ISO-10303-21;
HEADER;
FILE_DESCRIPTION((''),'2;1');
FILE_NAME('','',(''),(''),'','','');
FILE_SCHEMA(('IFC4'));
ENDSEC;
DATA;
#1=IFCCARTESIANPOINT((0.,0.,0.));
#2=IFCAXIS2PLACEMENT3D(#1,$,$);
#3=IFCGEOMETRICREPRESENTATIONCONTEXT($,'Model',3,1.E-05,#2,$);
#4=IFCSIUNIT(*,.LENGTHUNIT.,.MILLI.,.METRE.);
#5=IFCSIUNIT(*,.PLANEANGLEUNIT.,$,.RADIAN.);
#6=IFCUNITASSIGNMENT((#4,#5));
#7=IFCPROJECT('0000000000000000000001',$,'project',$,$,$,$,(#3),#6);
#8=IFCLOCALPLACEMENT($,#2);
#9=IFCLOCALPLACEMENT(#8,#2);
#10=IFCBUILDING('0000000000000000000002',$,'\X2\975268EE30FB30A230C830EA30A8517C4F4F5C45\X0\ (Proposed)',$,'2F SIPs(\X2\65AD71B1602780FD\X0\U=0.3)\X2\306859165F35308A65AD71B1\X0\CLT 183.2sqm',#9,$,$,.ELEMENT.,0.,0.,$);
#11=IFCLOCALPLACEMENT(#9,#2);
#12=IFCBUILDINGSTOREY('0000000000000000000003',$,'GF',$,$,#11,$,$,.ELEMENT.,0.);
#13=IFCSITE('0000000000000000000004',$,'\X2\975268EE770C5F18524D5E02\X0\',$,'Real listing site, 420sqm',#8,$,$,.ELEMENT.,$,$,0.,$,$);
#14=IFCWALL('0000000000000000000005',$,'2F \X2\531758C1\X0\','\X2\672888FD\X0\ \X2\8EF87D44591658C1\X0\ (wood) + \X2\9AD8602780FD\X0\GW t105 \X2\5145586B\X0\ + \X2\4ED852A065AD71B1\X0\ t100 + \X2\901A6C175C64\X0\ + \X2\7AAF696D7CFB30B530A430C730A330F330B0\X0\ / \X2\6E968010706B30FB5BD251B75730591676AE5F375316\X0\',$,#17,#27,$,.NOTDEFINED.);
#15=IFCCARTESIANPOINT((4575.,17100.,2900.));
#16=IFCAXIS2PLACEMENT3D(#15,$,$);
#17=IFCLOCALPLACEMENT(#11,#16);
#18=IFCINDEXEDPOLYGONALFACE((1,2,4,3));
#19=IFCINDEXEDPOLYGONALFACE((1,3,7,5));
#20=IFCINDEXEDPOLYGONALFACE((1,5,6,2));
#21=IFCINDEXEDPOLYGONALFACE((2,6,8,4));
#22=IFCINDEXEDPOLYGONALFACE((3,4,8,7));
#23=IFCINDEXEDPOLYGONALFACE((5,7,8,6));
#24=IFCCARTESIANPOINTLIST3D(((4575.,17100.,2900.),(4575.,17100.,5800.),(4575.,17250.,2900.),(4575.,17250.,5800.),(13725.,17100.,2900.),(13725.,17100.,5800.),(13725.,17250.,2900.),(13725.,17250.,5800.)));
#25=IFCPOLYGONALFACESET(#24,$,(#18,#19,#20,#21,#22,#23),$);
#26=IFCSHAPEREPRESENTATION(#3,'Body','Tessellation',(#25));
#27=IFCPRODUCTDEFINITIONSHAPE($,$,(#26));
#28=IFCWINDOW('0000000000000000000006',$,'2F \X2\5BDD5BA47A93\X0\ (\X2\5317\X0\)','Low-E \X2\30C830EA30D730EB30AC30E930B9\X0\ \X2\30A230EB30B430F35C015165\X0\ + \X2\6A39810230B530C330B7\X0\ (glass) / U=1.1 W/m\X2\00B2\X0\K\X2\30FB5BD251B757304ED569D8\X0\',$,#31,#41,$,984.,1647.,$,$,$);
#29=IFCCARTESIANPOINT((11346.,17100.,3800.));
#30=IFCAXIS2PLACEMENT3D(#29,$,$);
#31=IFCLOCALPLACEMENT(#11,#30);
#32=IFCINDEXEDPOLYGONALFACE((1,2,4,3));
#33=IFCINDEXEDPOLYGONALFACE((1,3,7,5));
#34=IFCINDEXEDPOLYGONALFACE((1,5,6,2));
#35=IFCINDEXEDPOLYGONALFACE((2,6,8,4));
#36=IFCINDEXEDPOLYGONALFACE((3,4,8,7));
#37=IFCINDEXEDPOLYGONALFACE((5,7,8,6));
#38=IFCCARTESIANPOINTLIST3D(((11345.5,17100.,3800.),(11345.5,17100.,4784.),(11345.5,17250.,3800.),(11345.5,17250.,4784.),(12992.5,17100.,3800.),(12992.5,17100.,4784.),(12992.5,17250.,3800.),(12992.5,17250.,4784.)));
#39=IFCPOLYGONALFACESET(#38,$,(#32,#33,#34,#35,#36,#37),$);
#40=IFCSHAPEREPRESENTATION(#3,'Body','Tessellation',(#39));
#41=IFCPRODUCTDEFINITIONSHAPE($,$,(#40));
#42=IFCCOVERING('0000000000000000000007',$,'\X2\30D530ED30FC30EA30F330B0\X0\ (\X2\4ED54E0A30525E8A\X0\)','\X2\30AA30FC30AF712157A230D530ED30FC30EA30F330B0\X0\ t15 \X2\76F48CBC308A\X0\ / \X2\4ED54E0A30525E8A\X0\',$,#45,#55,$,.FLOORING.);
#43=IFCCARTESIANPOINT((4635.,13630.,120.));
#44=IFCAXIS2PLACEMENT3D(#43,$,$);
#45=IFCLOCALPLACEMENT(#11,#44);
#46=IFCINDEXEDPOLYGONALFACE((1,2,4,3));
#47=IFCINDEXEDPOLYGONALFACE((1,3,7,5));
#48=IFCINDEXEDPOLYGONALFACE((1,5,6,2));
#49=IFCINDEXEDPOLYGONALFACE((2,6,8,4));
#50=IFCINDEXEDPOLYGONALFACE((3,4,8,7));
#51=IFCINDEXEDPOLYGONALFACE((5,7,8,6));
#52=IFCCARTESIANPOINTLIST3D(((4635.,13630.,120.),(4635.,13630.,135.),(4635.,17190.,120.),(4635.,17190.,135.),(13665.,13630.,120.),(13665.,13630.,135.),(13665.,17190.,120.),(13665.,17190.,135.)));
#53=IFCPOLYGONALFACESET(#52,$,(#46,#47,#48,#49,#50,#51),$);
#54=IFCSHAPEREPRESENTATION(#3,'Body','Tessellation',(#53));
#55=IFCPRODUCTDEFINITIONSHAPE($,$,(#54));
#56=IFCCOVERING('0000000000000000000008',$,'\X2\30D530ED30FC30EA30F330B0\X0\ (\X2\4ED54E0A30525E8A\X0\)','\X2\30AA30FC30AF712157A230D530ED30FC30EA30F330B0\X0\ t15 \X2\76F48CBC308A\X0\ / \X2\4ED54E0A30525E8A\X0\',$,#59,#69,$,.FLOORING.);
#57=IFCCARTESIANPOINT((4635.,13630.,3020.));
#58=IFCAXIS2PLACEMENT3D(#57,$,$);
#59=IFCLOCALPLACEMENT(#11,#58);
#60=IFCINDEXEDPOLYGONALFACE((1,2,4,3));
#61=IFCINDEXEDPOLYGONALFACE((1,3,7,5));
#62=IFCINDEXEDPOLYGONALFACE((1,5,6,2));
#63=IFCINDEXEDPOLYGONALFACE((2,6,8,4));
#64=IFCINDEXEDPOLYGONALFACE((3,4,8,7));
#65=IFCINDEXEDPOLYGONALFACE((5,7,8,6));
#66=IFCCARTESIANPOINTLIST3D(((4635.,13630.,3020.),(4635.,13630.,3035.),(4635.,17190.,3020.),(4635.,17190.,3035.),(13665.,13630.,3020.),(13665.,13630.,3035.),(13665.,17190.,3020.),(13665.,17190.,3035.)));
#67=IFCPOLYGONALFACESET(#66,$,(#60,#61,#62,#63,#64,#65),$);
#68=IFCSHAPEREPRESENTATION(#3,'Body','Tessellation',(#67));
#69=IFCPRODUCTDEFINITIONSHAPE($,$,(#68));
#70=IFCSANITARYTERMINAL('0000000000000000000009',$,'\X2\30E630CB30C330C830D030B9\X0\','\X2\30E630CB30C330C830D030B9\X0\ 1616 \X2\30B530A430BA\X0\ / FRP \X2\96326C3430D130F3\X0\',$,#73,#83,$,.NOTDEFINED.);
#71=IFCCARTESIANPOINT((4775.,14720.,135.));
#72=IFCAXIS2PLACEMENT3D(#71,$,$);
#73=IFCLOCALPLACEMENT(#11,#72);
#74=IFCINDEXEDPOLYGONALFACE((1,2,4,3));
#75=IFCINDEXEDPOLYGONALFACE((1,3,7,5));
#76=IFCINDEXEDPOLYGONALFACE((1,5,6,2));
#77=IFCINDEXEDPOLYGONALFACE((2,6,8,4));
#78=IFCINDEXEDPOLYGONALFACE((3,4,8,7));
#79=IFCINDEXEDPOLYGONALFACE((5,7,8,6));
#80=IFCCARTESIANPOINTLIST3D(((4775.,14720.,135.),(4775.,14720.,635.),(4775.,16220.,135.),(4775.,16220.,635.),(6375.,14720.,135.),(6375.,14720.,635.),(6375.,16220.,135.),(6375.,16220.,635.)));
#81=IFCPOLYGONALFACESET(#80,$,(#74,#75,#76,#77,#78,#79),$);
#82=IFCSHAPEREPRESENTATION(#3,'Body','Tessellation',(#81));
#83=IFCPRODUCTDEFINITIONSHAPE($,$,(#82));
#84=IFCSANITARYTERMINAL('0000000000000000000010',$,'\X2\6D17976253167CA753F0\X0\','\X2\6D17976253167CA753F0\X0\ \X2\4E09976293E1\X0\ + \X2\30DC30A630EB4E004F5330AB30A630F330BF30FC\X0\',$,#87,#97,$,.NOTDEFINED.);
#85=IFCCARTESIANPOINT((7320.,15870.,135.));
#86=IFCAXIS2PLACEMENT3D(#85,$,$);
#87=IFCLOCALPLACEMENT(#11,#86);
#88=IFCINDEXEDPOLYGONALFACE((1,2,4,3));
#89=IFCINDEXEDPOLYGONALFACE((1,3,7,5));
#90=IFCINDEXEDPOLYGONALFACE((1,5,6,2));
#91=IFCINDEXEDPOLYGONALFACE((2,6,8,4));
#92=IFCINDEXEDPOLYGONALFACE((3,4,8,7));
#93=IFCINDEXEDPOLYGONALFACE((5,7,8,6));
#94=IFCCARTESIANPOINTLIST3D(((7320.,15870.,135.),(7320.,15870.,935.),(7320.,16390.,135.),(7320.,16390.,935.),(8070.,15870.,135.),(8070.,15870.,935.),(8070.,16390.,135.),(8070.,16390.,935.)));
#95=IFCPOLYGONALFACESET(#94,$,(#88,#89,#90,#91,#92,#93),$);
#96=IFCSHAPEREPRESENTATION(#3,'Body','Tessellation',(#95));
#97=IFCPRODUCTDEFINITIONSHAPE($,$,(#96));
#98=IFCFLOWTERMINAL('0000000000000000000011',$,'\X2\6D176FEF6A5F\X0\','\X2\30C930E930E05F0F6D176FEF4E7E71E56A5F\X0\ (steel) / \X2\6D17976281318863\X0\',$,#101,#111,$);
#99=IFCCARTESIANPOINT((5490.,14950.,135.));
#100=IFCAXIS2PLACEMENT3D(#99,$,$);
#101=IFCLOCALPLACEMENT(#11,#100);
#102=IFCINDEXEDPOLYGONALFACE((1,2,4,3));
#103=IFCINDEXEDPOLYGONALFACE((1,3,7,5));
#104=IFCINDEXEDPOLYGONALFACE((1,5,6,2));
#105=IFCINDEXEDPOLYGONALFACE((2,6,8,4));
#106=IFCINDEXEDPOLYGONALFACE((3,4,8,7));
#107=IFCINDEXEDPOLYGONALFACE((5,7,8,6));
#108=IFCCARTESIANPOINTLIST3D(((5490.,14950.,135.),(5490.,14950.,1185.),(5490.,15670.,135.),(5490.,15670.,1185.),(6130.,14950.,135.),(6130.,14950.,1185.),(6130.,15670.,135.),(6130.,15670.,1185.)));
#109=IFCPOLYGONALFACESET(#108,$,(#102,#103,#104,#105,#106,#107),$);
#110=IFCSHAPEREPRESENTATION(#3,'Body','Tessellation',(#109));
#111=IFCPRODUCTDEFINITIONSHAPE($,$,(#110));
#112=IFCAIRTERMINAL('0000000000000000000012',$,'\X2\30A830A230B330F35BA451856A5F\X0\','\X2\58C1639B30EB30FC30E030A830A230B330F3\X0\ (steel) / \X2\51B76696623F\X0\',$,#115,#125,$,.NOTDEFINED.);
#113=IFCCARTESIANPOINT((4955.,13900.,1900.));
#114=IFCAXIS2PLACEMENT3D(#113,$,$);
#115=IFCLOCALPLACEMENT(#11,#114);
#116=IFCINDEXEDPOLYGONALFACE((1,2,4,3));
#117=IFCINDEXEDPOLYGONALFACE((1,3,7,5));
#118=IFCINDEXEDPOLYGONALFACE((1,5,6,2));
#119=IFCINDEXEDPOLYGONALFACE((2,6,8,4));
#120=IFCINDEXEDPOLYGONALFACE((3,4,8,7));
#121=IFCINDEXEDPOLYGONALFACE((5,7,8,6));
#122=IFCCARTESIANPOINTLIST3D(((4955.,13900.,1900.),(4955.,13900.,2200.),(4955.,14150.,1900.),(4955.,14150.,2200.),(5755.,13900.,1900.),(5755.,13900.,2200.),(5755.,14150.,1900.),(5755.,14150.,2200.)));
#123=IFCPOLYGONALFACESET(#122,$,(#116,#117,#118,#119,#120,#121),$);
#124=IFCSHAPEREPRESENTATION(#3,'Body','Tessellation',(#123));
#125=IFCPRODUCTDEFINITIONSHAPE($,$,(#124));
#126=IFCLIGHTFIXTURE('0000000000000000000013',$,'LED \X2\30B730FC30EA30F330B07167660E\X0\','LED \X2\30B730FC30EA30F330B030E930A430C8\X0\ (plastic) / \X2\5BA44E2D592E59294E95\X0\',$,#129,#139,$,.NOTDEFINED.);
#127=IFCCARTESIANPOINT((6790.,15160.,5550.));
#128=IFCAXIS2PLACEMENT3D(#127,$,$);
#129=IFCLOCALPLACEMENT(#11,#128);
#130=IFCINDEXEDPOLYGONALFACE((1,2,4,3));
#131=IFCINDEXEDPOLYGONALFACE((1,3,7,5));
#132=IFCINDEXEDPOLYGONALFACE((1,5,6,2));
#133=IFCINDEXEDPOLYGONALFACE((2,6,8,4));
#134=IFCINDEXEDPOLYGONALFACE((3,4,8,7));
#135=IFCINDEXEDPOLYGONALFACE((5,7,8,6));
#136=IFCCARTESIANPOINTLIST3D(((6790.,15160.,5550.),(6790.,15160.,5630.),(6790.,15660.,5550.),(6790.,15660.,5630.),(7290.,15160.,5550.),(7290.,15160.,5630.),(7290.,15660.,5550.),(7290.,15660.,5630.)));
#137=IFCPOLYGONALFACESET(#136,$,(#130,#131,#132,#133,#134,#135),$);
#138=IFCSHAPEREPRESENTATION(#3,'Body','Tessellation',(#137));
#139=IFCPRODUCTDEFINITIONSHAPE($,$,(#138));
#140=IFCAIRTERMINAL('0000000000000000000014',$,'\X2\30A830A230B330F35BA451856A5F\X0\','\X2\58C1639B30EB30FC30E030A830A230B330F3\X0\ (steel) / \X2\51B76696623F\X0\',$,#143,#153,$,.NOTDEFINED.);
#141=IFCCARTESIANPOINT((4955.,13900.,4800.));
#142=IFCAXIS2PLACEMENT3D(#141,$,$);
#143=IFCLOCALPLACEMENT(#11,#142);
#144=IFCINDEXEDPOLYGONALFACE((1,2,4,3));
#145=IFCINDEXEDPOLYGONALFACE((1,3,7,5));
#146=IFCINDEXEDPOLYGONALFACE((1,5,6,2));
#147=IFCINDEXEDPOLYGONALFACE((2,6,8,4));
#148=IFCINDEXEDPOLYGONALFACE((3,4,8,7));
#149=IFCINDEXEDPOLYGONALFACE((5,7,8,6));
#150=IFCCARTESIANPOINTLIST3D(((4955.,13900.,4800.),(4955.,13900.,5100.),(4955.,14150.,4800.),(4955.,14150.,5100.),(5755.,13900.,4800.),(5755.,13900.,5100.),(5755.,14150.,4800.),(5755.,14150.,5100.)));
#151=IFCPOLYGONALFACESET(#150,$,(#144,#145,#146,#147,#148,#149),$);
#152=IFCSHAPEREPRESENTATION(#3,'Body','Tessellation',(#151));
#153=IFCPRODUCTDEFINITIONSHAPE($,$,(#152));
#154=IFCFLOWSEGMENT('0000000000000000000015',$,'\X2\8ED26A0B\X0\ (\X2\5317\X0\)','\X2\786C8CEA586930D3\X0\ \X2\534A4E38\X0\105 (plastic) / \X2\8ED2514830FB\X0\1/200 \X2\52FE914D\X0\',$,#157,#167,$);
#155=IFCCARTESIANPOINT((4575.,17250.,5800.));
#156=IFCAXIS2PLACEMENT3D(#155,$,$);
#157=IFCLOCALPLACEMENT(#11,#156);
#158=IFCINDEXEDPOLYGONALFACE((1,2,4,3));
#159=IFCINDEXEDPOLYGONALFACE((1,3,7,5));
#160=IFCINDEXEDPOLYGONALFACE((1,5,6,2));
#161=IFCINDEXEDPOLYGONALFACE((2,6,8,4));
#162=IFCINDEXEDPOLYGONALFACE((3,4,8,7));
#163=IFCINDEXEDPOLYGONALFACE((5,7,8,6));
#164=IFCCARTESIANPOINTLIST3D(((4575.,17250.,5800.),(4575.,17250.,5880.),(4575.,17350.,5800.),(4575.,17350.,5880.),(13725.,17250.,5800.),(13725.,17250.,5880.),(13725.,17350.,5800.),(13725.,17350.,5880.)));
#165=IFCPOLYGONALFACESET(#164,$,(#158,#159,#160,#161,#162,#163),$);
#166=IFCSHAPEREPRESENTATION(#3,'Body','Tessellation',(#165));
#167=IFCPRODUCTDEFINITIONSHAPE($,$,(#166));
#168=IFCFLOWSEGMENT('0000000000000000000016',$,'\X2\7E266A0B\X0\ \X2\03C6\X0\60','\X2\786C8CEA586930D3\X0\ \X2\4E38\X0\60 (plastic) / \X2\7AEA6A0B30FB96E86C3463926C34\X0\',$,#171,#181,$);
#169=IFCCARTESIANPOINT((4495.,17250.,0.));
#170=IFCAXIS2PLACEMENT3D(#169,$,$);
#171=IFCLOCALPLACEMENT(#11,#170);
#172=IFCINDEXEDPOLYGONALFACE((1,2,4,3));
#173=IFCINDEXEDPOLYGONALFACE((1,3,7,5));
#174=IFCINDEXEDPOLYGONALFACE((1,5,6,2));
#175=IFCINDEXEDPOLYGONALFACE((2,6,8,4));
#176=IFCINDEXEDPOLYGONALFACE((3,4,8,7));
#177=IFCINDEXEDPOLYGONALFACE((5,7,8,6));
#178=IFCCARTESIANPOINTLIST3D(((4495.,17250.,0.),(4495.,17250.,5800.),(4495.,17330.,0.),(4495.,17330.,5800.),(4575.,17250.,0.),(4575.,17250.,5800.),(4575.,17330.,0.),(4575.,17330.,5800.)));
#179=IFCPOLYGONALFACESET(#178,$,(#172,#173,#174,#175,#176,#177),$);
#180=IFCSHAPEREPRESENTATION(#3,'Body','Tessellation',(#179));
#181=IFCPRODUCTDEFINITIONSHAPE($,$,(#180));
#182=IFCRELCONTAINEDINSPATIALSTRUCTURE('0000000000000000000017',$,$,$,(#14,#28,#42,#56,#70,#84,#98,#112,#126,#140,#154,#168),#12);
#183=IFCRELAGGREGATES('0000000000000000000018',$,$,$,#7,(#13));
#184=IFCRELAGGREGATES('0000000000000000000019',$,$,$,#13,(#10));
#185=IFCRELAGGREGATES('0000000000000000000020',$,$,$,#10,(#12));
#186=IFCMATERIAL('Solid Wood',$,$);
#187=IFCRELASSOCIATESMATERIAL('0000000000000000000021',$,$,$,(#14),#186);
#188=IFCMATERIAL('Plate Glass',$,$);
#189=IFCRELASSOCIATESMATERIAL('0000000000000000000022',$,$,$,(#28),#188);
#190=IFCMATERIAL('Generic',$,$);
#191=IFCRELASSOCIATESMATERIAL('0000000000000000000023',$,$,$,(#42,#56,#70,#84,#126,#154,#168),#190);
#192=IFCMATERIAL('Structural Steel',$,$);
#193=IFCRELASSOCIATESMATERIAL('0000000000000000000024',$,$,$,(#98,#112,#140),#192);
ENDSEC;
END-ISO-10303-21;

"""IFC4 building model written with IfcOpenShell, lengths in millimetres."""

from ifc_helpers import new_model, si_unit, frame, frame_2d, origin, place, context, project, spatial, rectangle, extrude, material, element, fill, save


model = new_model("IFC4")

# Units and contexts
model_context = context("Model", 3, precision=1e-05, world=origin())
ifc_project = project(units=[si_unit("LENGTHUNIT", "METRE", prefix="MILLI"), si_unit("PLANEANGLEUNIT", "RADIAN")], contexts=[model_context])

# Site, building, storey
site_placement = place(None, origin())
site = spatial("IfcSite", under=ifc_project, at=site_placement, Name="青森県弘前市", ObjectType="Real listing site, 420sqm", CompositionType="ELEMENT", RefElevation=0.0)
building_placement = place(site_placement, origin())
building = spatial("IfcBuilding", under=site, at=building_placement, Name="青森・アトリエ兼住居 (Proposed)", ObjectType="2F SIPs(断熱性能U=0.3)と外張り断熱CLT 183.2sqm", CompositionType="ELEMENT", ElevationOfRefHeight=0.0, ElevationOfTerrain=0.0)
storey_placement = place(building_placement, origin())
storey = spatial("IfcBuildingStorey", under=building, at=storey_placement, Name="GF", CompositionType="ELEMENT", Elevation=0.0)

# Shared definitions
ifc_material_1 = material(Name="Solid Wood")

# Shared definitions
ifc_material_2 = material(Name="Plate Glass")

# Wall, opening, window
wall_1_placement = place(storey_placement, frame((4575.0, 17100.0, 2900.0)))
wall_1 = element("IfcWall", 1, at=wall_1_placement, inside=storey, material=ifc_material_1, Name="2F 北壁", Description="木製 軸組外壁 (wood) + 高性能GW t105 充填 + 付加断熱 t100 + 通気層 + 窯業系サイディング / 準耐火・寒冷地外皮強化", PredefinedType="NOTDEFINED", context=model_context, shape_type="SweptSolid", body=[
    extrude(rectangle(XDim=9150.0, YDim=150.0, at=frame_2d((4575.0, 75.0))), frame((4575.0, 17100.0, 2900.0)), (0.0, 0.0, 1.0), 2900.0),
])
opening_1_placement = place(storey_placement, frame((11346.0, 17100.0, 3800.0)))
opening_1 = element("IfcOpeningElement", 2, at=opening_1_placement, cuts=wall_1, PredefinedType="NOTDEFINED", context=model_context, shape_type="SweptSolid", body=[
    extrude(rectangle(XDim=1647.0, YDim=150.0, at=frame_2d((823.0, 75.0))), frame((11346.0, 17100.0, 3800.0)), (0.0, 0.0, 1.0), 984.0),
])
window_1_placement = place(storey_placement, frame((11346.0, 17100.0, 3800.0)))
window_1 = element("IfcWindow", 3, at=window_1_placement, inside=storey, material=ifc_material_2, Name="2F 寝室窓 (北)", Description="Low-E トリプルガラス アルゴン封入 + 樹脂サッシ (glass) / U=1.1 W/m²K・寒冷地仕様", OverallHeight=984.0, OverallWidth=1647.0, context=model_context, shape_type="SweptSolid", body=[
    extrude(rectangle(XDim=1647.0, YDim=150.0, at=frame_2d((823.0, 75.0))), frame((11346.0, 17100.0, 3800.0)), (0.0, 0.0, 1.0), 984.0),
])
fill(opening_1, window_1)

# Coverings
ifc_material_3 = material(Name="Generic")
covering_1_placement = place(storey_placement, frame((4635.0, 13630.0, 120.0)))
element("IfcCovering", 4, at=covering_1_placement, inside=storey, material=ifc_material_3, Name="フローリング (仕上げ床)", Description="オーク無垢フローリング t15 直貼り / 仕上げ床", PredefinedType="FLOORING", context=model_context, shape_type="SweptSolid", body=[
    extrude(rectangle(XDim=9030.0, YDim=3560.0, at=frame_2d((4515.0, 1780.0))), frame((4635.0, 13630.0, 120.0)), (0.0, 0.0, 1.0), 15.0),
])
covering_2_placement = place(storey_placement, frame((4635.0, 13630.0, 3020.0)))
element("IfcCovering", 5, at=covering_2_placement, inside=storey, material=ifc_material_3, Name="フローリング (仕上げ床)", Description="オーク無垢フローリング t15 直貼り / 仕上げ床", PredefinedType="FLOORING", context=model_context, shape_type="SweptSolid", body=[
    extrude(rectangle(XDim=9030.0, YDim=3560.0, at=frame_2d((4515.0, 1780.0))), frame((4635.0, 13630.0, 3020.0)), (0.0, 0.0, 1.0), 15.0),
])

# Sanitary terminals
sanitary_terminal_1_placement = place(storey_placement, frame((4775.0, 14720.0, 135.0)))
element("IfcSanitaryTerminal", 6, at=sanitary_terminal_1_placement, inside=storey, material=ifc_material_3, Name="ユニットバス", Description="ユニットバス 1616 サイズ / FRP 防水パン", PredefinedType="NOTDEFINED", context=model_context, shape_type="SweptSolid", body=[
    extrude(rectangle(XDim=1600.0, YDim=1500.0, at=frame_2d((800.0, 750.0))), frame((4775.0, 14720.0, 135.0)), (0.0, 0.0, 1.0), 500.0),
])
sanitary_terminal_2_placement = place(storey_placement, frame((7320.0, 15870.0, 135.0)))
element("IfcSanitaryTerminal", 7, at=sanitary_terminal_2_placement, inside=storey, material=ifc_material_3, Name="洗面化粧台", Description="洗面化粧台 三面鏡 + ボウル一体カウンター", PredefinedType="NOTDEFINED", context=model_context, shape_type="SweptSolid", body=[
    extrude(rectangle(XDim=750.0, YDim=520.0, at=frame_2d((375.0, 260.0))), frame((7320.0, 15870.0, 135.0)), (0.0, 0.0, 1.0), 800.0),
])

# Flow terminal
ifc_material_4 = material(Name="Structural Steel")
flow_terminal_placement = place(storey_placement, frame((5490.0, 14950.0, 135.0)))
element("IfcFlowTerminal", 8, at=flow_terminal_placement, inside=storey, material=ifc_material_4, Name="洗濯機", Description="ドラム式洗濯乾燥機 (steel) / 洗面脱衣", context=model_context, shape_type="SweptSolid", body=[
    extrude(rectangle(XDim=640.0, YDim=720.0, at=frame_2d((320.0, 360.0))), frame((5490.0, 14950.0, 135.0)), (0.0, 0.0, 1.0), 1050.0),
])

# Air terminal
air_terminal_1_placement = place(storey_placement, frame((4955.0, 13900.0, 1900.0)))
element("IfcAirTerminal", 9, at=air_terminal_1_placement, inside=storey, material=ifc_material_4, Name="エアコン室内機", Description="壁掛ルームエアコン (steel) / 冷暖房", PredefinedType="NOTDEFINED", context=model_context, shape_type="SweptSolid", body=[
    extrude(rectangle(XDim=800.0, YDim=250.0, at=frame_2d((400.0, 125.0))), frame((4955.0, 13900.0, 1900.0)), (0.0, 0.0, 1.0), 300.0),
])

# Light fixture
light_fixture_placement = place(storey_placement, frame((6790.0, 15160.0, 5550.0)))
element("IfcLightFixture", 10, at=light_fixture_placement, inside=storey, material=ifc_material_3, Name="LED シーリング照明", Description="LED シーリングライト (plastic) / 室中央天井", PredefinedType="NOTDEFINED", context=model_context, shape_type="SweptSolid", body=[
    extrude(rectangle(XDim=500.0, YDim=500.0, at=frame_2d((250.0, 250.0))), frame((6790.0, 15160.0, 5550.0)), (0.0, 0.0, 1.0), 80.0),
])

# Air terminal
air_terminal_2_placement = place(storey_placement, frame((4955.0, 13900.0, 4800.0)))
element("IfcAirTerminal", 11, at=air_terminal_2_placement, inside=storey, material=ifc_material_4, Name="エアコン室内機", Description="壁掛ルームエアコン (steel) / 冷暖房", PredefinedType="NOTDEFINED", context=model_context, shape_type="SweptSolid", body=[
    extrude(rectangle(XDim=800.0, YDim=250.0, at=frame_2d((400.0, 125.0))), frame((4955.0, 13900.0, 4800.0)), (0.0, 0.0, 1.0), 300.0),
])

# Flow segments
flow_segment_1_placement = place(storey_placement, frame((4575.0, 17250.0, 5800.0)))
element("IfcFlowSegment", 12, at=flow_segment_1_placement, inside=storey, material=ifc_material_3, Name="軒樋 (北)", Description="硬質塩ビ 半丸105 (plastic) / 軒先・1/200 勾配", context=model_context, shape_type="SweptSolid", body=[
    extrude(rectangle(XDim=9150.0, YDim=100.0, at=frame_2d((4575.0, 50.0))), frame((4575.0, 17250.0, 5800.0)), (0.0, 0.0, 1.0), 80.0),
])
flow_segment_2_placement = place(storey_placement, frame((4495.0, 17250.0, 0.0)))
element("IfcFlowSegment", 13, at=flow_segment_2_placement, inside=storey, material=ifc_material_3, Name="縦樋 φ60", Description="硬質塩ビ 丸60 (plastic) / 竪樋・雨水排水", context=model_context, shape_type="SweptSolid", body=[
    extrude(rectangle(XDim=80.0, YDim=80.0, at=frame_2d((40.0, 40.0))), frame((4495.0, 17250.0, 0.0)), (0.0, 0.0, 1.0), 5800.0),
])

save(model, "model.ifc")
